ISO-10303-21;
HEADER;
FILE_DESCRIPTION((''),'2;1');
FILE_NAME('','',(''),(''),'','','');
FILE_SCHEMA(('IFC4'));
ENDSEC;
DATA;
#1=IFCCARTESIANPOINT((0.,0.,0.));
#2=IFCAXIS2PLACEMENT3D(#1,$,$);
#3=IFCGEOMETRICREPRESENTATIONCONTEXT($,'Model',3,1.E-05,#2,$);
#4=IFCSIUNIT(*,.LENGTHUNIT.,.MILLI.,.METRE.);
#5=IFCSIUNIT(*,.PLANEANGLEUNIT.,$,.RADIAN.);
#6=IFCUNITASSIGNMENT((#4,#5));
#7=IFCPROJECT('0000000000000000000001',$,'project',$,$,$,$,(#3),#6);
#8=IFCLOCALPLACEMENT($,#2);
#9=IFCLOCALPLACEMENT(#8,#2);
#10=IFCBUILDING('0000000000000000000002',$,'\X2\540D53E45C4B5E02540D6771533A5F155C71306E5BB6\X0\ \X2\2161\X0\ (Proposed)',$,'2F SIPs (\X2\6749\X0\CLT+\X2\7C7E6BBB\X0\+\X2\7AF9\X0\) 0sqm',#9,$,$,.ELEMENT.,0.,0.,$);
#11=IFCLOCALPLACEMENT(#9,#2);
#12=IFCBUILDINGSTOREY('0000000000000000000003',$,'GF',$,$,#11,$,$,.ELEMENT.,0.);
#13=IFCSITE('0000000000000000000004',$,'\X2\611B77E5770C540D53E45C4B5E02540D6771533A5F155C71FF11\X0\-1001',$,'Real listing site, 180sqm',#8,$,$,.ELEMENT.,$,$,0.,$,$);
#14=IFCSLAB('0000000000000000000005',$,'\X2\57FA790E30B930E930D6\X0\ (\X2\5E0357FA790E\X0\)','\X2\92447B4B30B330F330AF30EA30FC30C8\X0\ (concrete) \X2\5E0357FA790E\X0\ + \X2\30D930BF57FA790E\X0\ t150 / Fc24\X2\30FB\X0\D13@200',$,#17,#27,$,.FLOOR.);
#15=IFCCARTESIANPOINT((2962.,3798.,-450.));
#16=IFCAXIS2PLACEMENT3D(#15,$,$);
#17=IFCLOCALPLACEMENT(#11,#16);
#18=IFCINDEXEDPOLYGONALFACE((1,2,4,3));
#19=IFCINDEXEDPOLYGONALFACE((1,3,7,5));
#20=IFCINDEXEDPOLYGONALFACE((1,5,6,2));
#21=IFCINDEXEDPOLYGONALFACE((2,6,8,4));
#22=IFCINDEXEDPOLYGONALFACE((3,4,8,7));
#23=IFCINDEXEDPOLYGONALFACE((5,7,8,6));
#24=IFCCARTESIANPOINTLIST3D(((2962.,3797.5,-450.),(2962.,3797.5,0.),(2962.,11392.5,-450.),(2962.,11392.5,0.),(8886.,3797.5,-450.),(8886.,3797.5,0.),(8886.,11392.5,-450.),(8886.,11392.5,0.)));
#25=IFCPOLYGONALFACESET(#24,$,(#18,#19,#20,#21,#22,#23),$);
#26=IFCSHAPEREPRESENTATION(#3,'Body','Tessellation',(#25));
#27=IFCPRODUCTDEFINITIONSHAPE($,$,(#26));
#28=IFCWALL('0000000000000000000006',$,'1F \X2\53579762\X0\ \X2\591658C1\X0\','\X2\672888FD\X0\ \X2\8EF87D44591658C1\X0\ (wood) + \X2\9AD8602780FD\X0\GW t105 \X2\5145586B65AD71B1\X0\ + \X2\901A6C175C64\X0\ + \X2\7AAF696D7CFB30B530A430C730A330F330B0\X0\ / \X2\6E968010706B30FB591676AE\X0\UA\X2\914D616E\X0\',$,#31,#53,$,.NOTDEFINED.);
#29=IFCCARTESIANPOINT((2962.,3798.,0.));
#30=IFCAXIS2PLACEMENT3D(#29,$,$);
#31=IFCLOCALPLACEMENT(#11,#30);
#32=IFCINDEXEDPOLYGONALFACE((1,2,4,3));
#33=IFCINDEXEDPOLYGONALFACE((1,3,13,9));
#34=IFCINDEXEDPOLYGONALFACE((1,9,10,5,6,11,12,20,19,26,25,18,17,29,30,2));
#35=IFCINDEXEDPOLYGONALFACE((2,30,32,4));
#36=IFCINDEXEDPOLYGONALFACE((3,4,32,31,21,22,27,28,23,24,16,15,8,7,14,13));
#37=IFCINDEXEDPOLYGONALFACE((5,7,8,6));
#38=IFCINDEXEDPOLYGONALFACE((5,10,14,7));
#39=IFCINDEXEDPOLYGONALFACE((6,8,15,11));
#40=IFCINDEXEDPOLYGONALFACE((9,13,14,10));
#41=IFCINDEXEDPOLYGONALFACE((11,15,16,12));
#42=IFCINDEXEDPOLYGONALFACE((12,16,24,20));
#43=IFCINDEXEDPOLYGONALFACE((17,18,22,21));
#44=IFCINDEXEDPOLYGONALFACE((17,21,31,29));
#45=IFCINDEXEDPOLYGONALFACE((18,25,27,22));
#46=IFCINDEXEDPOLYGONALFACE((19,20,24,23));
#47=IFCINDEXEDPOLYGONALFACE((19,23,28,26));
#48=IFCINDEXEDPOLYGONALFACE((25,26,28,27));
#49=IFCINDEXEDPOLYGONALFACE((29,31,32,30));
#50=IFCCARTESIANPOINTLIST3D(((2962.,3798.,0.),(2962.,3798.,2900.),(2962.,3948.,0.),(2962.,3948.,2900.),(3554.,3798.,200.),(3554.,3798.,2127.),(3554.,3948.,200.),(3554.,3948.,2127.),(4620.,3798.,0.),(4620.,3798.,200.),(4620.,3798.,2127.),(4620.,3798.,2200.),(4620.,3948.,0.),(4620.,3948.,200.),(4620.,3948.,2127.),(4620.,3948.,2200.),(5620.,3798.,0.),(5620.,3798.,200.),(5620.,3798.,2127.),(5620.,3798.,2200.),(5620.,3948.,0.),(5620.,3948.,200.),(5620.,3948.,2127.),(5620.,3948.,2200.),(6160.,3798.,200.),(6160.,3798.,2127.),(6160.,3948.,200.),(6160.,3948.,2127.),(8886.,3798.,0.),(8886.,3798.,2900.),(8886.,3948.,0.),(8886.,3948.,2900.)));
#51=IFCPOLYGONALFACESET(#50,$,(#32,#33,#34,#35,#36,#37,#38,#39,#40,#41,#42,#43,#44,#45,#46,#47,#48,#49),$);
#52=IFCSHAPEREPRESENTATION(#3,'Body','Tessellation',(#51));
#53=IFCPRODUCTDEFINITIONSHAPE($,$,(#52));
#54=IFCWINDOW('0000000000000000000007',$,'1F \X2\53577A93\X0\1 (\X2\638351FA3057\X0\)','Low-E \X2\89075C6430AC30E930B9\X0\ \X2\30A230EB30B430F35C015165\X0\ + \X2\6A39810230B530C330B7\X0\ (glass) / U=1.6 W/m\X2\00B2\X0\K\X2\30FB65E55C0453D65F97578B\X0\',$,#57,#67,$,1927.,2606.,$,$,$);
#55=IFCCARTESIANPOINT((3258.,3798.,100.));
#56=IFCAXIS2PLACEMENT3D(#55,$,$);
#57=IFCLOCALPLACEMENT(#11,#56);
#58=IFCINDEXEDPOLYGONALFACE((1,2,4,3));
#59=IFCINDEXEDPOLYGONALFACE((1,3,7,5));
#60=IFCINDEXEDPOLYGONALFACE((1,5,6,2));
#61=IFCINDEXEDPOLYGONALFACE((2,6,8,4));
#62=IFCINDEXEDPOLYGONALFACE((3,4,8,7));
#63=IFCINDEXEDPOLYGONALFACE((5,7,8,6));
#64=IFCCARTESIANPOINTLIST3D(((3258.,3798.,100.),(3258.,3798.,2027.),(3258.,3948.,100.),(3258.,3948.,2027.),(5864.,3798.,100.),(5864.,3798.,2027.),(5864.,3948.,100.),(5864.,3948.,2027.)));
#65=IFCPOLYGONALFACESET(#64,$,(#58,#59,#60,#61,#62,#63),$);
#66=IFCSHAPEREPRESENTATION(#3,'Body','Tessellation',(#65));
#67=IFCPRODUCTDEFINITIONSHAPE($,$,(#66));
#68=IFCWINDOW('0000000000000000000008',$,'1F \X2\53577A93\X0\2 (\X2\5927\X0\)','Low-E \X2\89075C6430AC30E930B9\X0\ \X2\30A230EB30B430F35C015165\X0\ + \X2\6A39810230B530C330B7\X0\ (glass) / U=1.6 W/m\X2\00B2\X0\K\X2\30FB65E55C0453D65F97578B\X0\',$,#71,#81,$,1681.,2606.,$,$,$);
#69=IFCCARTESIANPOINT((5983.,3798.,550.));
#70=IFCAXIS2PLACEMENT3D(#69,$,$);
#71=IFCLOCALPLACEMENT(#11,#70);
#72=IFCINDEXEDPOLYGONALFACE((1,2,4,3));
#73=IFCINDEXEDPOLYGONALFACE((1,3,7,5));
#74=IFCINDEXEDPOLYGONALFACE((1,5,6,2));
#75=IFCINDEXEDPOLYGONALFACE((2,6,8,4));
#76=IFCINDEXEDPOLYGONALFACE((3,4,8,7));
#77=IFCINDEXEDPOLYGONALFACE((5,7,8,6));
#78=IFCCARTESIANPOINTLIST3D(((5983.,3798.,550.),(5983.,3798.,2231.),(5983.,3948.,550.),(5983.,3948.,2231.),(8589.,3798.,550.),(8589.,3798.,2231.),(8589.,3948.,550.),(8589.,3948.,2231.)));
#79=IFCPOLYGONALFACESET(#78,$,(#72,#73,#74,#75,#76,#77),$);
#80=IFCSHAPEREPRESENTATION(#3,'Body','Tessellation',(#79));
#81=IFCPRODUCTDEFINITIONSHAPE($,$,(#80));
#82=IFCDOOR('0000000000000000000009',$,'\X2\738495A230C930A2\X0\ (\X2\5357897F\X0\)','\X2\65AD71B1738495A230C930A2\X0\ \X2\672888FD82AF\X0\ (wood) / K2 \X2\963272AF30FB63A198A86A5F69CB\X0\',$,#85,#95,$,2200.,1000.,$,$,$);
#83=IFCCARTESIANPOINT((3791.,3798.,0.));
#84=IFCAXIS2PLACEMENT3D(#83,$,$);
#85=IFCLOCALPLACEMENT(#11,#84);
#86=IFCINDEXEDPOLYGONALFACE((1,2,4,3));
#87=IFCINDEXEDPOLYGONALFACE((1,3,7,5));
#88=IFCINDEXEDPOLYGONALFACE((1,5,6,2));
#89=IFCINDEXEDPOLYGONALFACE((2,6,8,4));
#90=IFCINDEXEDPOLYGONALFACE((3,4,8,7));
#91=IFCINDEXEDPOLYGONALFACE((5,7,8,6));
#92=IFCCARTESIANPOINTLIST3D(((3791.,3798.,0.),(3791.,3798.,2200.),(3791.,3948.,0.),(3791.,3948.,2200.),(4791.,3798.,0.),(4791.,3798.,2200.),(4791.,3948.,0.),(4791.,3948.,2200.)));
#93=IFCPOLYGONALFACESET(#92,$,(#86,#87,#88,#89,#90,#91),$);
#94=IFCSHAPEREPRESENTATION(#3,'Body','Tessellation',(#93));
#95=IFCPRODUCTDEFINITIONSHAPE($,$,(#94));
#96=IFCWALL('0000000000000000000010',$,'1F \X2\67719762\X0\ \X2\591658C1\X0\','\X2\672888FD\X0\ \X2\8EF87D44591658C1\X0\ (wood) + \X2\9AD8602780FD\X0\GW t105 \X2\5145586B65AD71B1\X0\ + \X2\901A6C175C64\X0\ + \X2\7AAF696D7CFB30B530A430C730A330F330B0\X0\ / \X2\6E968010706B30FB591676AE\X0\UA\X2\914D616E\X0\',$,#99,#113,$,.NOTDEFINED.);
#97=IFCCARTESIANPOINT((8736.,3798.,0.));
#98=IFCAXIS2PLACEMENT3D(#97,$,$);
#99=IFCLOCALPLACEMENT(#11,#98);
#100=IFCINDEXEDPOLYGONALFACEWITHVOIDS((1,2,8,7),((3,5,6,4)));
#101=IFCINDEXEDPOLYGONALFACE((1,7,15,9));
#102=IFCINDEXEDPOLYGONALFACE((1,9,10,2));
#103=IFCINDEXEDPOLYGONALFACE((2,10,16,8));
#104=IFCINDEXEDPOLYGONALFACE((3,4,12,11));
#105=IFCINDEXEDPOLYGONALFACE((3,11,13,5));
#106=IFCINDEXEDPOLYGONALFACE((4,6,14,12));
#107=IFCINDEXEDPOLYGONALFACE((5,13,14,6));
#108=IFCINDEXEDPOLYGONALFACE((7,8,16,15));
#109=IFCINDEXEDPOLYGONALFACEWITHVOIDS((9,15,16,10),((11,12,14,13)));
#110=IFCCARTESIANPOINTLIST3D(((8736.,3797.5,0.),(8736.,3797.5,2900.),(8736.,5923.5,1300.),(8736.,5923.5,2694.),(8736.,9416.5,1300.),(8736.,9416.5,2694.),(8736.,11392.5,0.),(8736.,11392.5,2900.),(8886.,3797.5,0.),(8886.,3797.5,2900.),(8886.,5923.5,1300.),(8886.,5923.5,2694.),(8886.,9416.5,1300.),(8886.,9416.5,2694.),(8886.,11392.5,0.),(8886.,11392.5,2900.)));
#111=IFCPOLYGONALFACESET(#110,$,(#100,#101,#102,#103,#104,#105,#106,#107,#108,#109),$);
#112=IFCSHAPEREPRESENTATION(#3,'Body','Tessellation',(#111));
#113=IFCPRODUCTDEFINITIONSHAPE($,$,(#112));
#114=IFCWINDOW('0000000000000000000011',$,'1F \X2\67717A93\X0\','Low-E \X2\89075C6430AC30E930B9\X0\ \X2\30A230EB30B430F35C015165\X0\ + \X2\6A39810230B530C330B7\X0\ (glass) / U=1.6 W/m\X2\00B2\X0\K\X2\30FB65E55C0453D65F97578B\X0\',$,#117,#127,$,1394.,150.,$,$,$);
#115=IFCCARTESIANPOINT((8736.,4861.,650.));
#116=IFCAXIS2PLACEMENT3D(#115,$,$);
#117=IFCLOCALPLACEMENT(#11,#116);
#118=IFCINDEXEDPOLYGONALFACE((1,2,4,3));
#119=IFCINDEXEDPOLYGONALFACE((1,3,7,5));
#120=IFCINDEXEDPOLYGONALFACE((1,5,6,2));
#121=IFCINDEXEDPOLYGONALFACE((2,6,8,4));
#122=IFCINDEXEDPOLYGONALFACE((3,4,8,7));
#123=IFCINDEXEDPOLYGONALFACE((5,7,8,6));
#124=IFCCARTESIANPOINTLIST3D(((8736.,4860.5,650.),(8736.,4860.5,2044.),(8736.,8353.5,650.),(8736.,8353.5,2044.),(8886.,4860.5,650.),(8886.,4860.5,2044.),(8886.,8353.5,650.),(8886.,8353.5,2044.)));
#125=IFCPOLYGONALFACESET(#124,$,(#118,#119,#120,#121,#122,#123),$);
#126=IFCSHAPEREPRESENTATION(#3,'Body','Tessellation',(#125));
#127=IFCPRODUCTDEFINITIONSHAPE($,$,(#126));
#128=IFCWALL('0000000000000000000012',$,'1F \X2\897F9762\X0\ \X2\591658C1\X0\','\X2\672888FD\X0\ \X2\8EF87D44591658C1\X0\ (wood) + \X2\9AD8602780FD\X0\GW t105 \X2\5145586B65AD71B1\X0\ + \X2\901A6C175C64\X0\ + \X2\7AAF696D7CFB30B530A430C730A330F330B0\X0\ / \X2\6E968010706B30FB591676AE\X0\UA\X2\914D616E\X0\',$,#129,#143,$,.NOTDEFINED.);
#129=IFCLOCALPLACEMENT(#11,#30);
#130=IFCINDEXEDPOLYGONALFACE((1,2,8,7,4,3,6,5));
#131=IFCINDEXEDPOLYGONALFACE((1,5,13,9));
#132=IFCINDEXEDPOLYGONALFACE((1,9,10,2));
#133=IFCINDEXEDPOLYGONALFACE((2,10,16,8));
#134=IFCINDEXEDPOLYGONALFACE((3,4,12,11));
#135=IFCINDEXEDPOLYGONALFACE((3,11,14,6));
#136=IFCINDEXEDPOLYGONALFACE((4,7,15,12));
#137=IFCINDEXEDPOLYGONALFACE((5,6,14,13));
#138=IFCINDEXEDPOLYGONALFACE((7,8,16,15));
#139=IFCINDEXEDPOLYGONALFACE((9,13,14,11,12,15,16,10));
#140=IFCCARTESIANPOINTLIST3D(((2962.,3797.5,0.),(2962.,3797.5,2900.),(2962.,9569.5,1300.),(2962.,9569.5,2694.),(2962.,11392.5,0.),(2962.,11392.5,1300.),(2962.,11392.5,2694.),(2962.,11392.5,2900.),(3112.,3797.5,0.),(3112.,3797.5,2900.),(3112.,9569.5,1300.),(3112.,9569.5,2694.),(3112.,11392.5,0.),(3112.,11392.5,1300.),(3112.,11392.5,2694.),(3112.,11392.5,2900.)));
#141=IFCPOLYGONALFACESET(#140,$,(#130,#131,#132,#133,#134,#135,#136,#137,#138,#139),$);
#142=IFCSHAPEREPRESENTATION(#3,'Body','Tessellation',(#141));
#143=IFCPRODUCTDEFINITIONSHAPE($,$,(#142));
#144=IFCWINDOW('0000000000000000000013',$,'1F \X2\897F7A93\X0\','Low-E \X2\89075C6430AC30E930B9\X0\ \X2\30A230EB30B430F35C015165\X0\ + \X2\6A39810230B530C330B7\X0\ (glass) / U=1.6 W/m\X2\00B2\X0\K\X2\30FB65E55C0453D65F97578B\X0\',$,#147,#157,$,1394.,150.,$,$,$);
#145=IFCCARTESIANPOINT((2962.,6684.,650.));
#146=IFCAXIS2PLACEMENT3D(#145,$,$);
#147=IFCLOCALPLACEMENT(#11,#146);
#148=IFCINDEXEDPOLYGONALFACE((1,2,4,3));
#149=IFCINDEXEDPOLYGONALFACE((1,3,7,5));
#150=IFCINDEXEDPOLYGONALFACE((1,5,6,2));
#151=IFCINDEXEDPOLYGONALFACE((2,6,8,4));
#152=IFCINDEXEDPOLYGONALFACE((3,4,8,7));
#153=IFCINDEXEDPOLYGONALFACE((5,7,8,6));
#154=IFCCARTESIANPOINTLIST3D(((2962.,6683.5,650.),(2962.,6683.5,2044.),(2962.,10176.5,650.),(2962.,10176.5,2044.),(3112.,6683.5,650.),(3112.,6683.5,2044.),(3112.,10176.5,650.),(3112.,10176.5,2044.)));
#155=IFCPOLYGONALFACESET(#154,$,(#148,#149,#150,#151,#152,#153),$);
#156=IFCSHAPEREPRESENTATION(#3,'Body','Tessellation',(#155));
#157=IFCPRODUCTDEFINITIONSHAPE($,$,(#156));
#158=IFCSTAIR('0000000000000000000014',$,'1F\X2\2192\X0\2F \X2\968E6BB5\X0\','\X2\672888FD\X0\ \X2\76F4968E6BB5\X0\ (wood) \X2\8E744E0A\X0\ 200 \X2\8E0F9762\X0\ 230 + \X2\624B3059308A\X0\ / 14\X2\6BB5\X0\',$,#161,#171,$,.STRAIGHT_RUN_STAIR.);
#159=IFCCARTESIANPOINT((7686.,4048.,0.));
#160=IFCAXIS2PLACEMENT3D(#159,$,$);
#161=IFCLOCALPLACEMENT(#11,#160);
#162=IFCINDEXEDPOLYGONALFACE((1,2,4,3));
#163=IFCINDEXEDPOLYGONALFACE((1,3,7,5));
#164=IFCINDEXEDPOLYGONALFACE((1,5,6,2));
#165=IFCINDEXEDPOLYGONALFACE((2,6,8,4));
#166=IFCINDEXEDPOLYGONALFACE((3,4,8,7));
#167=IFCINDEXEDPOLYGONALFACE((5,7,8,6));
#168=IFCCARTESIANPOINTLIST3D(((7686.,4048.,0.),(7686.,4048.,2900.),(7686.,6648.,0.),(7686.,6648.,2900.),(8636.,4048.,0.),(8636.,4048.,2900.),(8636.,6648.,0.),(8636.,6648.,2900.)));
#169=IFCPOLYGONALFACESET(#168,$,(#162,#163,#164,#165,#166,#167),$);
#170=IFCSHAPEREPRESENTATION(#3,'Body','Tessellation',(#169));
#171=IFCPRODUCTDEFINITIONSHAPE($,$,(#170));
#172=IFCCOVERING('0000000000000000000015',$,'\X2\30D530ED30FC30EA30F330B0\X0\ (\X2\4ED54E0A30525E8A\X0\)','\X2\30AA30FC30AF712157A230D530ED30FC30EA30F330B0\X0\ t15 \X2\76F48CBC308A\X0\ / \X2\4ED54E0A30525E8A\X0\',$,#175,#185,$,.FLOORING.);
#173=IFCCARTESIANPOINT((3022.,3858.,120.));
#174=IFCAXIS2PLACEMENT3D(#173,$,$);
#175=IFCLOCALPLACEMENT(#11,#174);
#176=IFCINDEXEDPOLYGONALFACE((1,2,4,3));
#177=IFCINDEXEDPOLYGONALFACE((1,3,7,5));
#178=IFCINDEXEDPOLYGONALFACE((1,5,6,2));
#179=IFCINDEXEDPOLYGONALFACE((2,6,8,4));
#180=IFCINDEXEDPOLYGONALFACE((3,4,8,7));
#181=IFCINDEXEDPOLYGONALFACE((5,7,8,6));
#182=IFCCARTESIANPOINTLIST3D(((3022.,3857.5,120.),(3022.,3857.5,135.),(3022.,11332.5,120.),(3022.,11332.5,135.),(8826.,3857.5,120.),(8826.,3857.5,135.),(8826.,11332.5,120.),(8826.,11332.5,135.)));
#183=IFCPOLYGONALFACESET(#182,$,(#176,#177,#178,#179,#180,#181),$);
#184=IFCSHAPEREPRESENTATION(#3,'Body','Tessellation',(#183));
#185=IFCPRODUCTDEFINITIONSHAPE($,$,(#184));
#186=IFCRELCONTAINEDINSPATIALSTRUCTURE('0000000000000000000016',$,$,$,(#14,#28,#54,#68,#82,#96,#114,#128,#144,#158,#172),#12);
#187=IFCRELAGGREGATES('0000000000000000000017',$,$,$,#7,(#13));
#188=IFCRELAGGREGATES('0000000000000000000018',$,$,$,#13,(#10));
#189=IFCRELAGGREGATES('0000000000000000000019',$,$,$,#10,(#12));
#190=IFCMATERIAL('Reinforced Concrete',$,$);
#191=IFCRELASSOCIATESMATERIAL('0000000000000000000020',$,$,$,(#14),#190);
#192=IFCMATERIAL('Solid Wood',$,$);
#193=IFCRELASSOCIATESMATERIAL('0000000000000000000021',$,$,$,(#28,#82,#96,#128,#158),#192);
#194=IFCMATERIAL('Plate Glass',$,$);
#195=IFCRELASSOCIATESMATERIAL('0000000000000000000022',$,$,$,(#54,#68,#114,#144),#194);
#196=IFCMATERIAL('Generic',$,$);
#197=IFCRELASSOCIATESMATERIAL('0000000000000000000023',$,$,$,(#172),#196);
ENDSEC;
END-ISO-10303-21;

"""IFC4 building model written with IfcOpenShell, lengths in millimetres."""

from ifc_helpers import new_model, si_unit, frame, frame_2d, origin, place, context, project, spatial, rectangle, extrude, material, element, fill, save


model = new_model("IFC4")

# Units and contexts
model_context = context("Model", 3, precision=1e-05, world=origin())
ifc_project = project(units=[si_unit("LENGTHUNIT", "METRE", prefix="MILLI"), si_unit("PLANEANGLEUNIT", "RADIAN")], contexts=[model_context])

# Site, building, storey
site_placement = place(None, origin())
site = spatial("IfcSite", under=ifc_project, at=site_placement, Name="愛知県名古屋市名東区引山１-1001", ObjectType="Real listing site, 180sqm", CompositionType="ELEMENT", RefElevation=0.0)
building_placement = place(site_placement, origin())
building = spatial("IfcBuilding", under=site, at=building_placement, Name="名古屋市名東区引山の家 Ⅱ (Proposed)", ObjectType="2F SIPs (杉CLT+籾殻+竹) 0sqm", CompositionType="ELEMENT", ElevationOfRefHeight=0.0, ElevationOfTerrain=0.0)
storey_placement = place(building_placement, origin())
storey = spatial("IfcBuildingStorey", under=building, at=storey_placement, Name="GF", CompositionType="ELEMENT", Elevation=0.0)

# Slab
ifc_material_1 = material(Name="Reinforced Concrete")
slab_1_placement = place(storey_placement, frame((2962.0, 3798.0, -450.0)))
element("IfcSlab", 1, at=slab_1_placement, inside=storey, material=ifc_material_1, Name="基礎スラブ (布基礎)", Description="鉄筋コンクリート (concrete) 布基礎 + ベタ基礎 t150 / Fc24・D13@200", PredefinedType="FLOOR", context=model_context, shape_type="SweptSolid", body=[
    extrude(rectangle(XDim=5924.0, YDim=7595.0, at=frame_2d((2962.0, 3797.0))), frame((2962.0, 3798.0, -450.0)), (0.0, 0.0, 1.0), 450.0),
])
ifc_material_2 = material(Name="Solid Wood")

# Wall, openings, windows, door
wall_1_placement = place(storey_placement, frame((2962.0, 3798.0, 0.0)))
wall_1 = element("IfcWall", 2, at=wall_1_placement, inside=storey, material=ifc_material_2, Name="1F 南面 外壁", Description="木製 軸組外壁 (wood) + 高性能GW t105 充填断熱 + 通気層 + 窯業系サイディング / 準耐火・外皮UA配慮", PredefinedType="NOTDEFINED", context=model_context, shape_type="SweptSolid", body=[
    extrude(rectangle(XDim=5924.0, YDim=150.0, at=frame_2d((2962.0, 75.0))), frame((2962.0, 3798.0, 0.0)), (0.0, 0.0, 1.0), 2900.0),
])
opening_1_placement = place(storey_placement, frame((3258.0, 3798.0, 100.0)))
opening_1 = element("IfcOpeningElement", 3, at=opening_1_placement, cuts=wall_1, PredefinedType="NOTDEFINED", context=model_context, shape_type="SweptSolid", body=[
    extrude(rectangle(XDim=2606.0, YDim=150.0, at=frame_2d((1303.0, 75.0))), frame((3258.0, 3798.0, 100.0)), (0.0, 0.0, 1.0), 1927.0),
])
opening_2_placement = place(storey_placement, frame((5983.0, 3798.0, 550.0)))
opening_2 = element("IfcOpeningElement", 4, at=opening_2_placement, cuts=wall_1, PredefinedType="NOTDEFINED", context=model_context, shape_type="SweptSolid", body=[
    extrude(rectangle(XDim=2606.0, YDim=150.0, at=frame_2d((1303.0, 75.0))), frame((5983.0, 3798.0, 550.0)), (0.0, 0.0, 1.0), 1681.0),
])
opening_3_placement = place(storey_placement, frame((3791.0, 3798.0, 0.0)))
opening_3 = element("IfcOpeningElement", 5, at=opening_3_placement, cuts=wall_1, PredefinedType="NOTDEFINED", context=model_context, shape_type="SweptSolid", body=[
    extrude(rectangle(XDim=1000.0, YDim=150.0, at=frame_2d((500.0, 75.0))), frame((3791.0, 3798.0, 0.0)), (0.0, 0.0, 1.0), 2200.0),
])
ifc_material_3 = material(Name="Plate Glass")
window_1_placement = place(storey_placement, frame((3258.0, 3798.0, 100.0)))
window_1 = element("IfcWindow", 6, at=window_1_placement, inside=storey, material=ifc_material_3, Name="1F 南窓1 (掃出し)", Description="Low-E 複層ガラス アルゴン封入 + 樹脂サッシ (glass) / U=1.6 W/m²K・日射取得型", OverallHeight=1927.0, OverallWidth=2606.0, context=model_context, shape_type="SweptSolid", body=[
    extrude(rectangle(XDim=2606.0, YDim=150.0, at=frame_2d((1303.0, 75.0))), frame((3258.0, 3798.0, 100.0)), (0.0, 0.0, 1.0), 1927.0),
])
fill(opening_1, window_1)
window_2_placement = place(storey_placement, frame((5983.0, 3798.0, 550.0)))
window_2 = element("IfcWindow", 7, at=window_2_placement, inside=storey, material=ifc_material_3, Name="1F 南窓2 (大)", Description="Low-E 複層ガラス アルゴン封入 + 樹脂サッシ (glass) / U=1.6 W/m²K・日射取得型", OverallHeight=1681.0, OverallWidth=2606.0, context=model_context, shape_type="SweptSolid", body=[
    extrude(rectangle(XDim=2606.0, YDim=150.0, at=frame_2d((1303.0, 75.0))), frame((5983.0, 3798.0, 550.0)), (0.0, 0.0, 1.0), 1681.0),
])
fill(opening_2, window_2)
door_placement = place(storey_placement, frame((3791.0, 3798.0, 0.0)))
door = element("IfcDoor", 8, at=door_placement, inside=storey, material=ifc_material_2, Name="玄関ドア (南西)", Description="断熱玄関ドア 木製芯 (wood) / K2 防犯・採風機構", OverallHeight=2200.0, OverallWidth=1000.0, context=model_context, shape_type="SweptSolid", body=[
    extrude(rectangle(XDim=1000.0, YDim=150.0, at=frame_2d((500.0, 75.0))), frame((3791.0, 3798.0, 0.0)), (0.0, 0.0, 1.0), 2200.0),
])
fill(opening_3, door)

# Walls, openings, windows
wall_2_placement = place(storey_placement, frame((8736.0, 3798.0, 0.0)))
wall_2 = element("IfcWall", 9, at=wall_2_placement, inside=storey, material=ifc_material_2, Name="1F 東面 外壁", Description="木製 軸組外壁 (wood) + 高性能GW t105 充填断熱 + 通気層 + 窯業系サイディング / 準耐火・外皮UA配慮", PredefinedType="NOTDEFINED", context=model_context, shape_type="SweptSolid", body=[
    extrude(rectangle(XDim=150.0, YDim=7595.0, at=frame_2d((75.0, 3797.0))), frame((8736.0, 3798.0, 0.0)), (0.0, 0.0, 1.0), 2900.0),
])
opening_4_placement = place(storey_placement, frame((8736.0, 4861.0, 650.0)))
opening_4 = element("IfcOpeningElement", 10, at=opening_4_placement, cuts=wall_2, PredefinedType="NOTDEFINED", context=model_context, shape_type="SweptSolid", body=[
    extrude(rectangle(XDim=150.0, YDim=3493.0, at=frame_2d((75.0, 1746.0))), frame((8736.0, 4861.0, 650.0)), (0.0, 0.0, 1.0), 1394.0),
])
window_3_placement = place(storey_placement, frame((8736.0, 4861.0, 650.0)))
window_3 = element("IfcWindow", 11, at=window_3_placement, inside=storey, material=ifc_material_3, Name="1F 東窓", Description="Low-E 複層ガラス アルゴン封入 + 樹脂サッシ (glass) / U=1.6 W/m²K・日射取得型", OverallHeight=1394.0, OverallWidth=150.0, context=model_context, shape_type="SweptSolid", body=[
    extrude(rectangle(XDim=150.0, YDim=3493.0, at=frame_2d((75.0, 1746.0))), frame((8736.0, 4861.0, 650.0)), (0.0, 0.0, 1.0), 1394.0),
])
fill(opening_4, window_3)
wall_3_placement = place(storey_placement, frame((2962.0, 3798.0, 0.0)))
wall_3 = element("IfcWall", 12, at=wall_3_placement, inside=storey, material=ifc_material_2, Name="1F 西面 外壁", Description="木製 軸組外壁 (wood) + 高性能GW t105 充填断熱 + 通気層 + 窯業系サイディング / 準耐火・外皮UA配慮", PredefinedType="NOTDEFINED", context=model_context, shape_type="SweptSolid", body=[
    extrude(rectangle(XDim=150.0, YDim=7595.0, at=frame_2d((75.0, 3797.0))), frame((2962.0, 3798.0, 0.0)), (0.0, 0.0, 1.0), 2900.0),
])
opening_5_placement = place(storey_placement, frame((2962.0, 6684.0, 650.0)))
opening_5 = element("IfcOpeningElement", 13, at=opening_5_placement, cuts=wall_3, PredefinedType="NOTDEFINED", context=model_context, shape_type="SweptSolid", body=[
    extrude(rectangle(XDim=150.0, YDim=3493.0, at=frame_2d((75.0, 1746.0))), frame((2962.0, 6684.0, 650.0)), (0.0, 0.0, 1.0), 1394.0),
])
window_4_placement = place(storey_placement, frame((2962.0, 6684.0, 650.0)))
window_4 = element("IfcWindow", 14, at=window_4_placement, inside=storey, material=ifc_material_3, Name="1F 西窓", Description="Low-E 複層ガラス アルゴン封入 + 樹脂サッシ (glass) / U=1.6 W/m²K・日射取得型", OverallHeight=1394.0, OverallWidth=150.0, context=model_context, shape_type="SweptSolid", body=[
    extrude(rectangle(XDim=150.0, YDim=3493.0, at=frame_2d((75.0, 1746.0))), frame((2962.0, 6684.0, 650.0)), (0.0, 0.0, 1.0), 1394.0),
])
fill(opening_5, window_4)

# Stair
stair_placement = place(storey_placement, frame((7686.0, 4048.0, 0.0)))
element("IfcStair", 15, at=stair_placement, inside=storey, material=ifc_material_2, Name="1F→2F 階段", Description="木製 直階段 (wood) 蹴上 200 踏面 230 + 手すり / 14段", PredefinedType="STRAIGHT_RUN_STAIR", context=model_context, shape_type="SweptSolid", body=[
    extrude(rectangle(XDim=950.0, YDim=2600.0, at=frame_2d((475.0, 1300.0))), frame((7686.0, 4048.0, 0.0)), (0.0, 0.0, 1.0), 2900.0),
])

# Covering
ifc_material_4 = material(Name="Generic")
covering_placement = place(storey_placement, frame((3022.0, 3858.0, 120.0)))
element("IfcCovering", 16, at=covering_placement, inside=storey, material=ifc_material_4, Name="フローリング (仕上げ床)", Description="オーク無垢フローリング t15 直貼り / 仕上げ床", PredefinedType="FLOORING", context=model_context, shape_type="SweptSolid", body=[
    extrude(rectangle(XDim=5804.0, YDim=7475.0, at=frame_2d((2902.0, 3737.0))), frame((3022.0, 3858.0, 120.0)), (0.0, 0.0, 1.0), 15.0),
])

save(model, "model.ifc")
